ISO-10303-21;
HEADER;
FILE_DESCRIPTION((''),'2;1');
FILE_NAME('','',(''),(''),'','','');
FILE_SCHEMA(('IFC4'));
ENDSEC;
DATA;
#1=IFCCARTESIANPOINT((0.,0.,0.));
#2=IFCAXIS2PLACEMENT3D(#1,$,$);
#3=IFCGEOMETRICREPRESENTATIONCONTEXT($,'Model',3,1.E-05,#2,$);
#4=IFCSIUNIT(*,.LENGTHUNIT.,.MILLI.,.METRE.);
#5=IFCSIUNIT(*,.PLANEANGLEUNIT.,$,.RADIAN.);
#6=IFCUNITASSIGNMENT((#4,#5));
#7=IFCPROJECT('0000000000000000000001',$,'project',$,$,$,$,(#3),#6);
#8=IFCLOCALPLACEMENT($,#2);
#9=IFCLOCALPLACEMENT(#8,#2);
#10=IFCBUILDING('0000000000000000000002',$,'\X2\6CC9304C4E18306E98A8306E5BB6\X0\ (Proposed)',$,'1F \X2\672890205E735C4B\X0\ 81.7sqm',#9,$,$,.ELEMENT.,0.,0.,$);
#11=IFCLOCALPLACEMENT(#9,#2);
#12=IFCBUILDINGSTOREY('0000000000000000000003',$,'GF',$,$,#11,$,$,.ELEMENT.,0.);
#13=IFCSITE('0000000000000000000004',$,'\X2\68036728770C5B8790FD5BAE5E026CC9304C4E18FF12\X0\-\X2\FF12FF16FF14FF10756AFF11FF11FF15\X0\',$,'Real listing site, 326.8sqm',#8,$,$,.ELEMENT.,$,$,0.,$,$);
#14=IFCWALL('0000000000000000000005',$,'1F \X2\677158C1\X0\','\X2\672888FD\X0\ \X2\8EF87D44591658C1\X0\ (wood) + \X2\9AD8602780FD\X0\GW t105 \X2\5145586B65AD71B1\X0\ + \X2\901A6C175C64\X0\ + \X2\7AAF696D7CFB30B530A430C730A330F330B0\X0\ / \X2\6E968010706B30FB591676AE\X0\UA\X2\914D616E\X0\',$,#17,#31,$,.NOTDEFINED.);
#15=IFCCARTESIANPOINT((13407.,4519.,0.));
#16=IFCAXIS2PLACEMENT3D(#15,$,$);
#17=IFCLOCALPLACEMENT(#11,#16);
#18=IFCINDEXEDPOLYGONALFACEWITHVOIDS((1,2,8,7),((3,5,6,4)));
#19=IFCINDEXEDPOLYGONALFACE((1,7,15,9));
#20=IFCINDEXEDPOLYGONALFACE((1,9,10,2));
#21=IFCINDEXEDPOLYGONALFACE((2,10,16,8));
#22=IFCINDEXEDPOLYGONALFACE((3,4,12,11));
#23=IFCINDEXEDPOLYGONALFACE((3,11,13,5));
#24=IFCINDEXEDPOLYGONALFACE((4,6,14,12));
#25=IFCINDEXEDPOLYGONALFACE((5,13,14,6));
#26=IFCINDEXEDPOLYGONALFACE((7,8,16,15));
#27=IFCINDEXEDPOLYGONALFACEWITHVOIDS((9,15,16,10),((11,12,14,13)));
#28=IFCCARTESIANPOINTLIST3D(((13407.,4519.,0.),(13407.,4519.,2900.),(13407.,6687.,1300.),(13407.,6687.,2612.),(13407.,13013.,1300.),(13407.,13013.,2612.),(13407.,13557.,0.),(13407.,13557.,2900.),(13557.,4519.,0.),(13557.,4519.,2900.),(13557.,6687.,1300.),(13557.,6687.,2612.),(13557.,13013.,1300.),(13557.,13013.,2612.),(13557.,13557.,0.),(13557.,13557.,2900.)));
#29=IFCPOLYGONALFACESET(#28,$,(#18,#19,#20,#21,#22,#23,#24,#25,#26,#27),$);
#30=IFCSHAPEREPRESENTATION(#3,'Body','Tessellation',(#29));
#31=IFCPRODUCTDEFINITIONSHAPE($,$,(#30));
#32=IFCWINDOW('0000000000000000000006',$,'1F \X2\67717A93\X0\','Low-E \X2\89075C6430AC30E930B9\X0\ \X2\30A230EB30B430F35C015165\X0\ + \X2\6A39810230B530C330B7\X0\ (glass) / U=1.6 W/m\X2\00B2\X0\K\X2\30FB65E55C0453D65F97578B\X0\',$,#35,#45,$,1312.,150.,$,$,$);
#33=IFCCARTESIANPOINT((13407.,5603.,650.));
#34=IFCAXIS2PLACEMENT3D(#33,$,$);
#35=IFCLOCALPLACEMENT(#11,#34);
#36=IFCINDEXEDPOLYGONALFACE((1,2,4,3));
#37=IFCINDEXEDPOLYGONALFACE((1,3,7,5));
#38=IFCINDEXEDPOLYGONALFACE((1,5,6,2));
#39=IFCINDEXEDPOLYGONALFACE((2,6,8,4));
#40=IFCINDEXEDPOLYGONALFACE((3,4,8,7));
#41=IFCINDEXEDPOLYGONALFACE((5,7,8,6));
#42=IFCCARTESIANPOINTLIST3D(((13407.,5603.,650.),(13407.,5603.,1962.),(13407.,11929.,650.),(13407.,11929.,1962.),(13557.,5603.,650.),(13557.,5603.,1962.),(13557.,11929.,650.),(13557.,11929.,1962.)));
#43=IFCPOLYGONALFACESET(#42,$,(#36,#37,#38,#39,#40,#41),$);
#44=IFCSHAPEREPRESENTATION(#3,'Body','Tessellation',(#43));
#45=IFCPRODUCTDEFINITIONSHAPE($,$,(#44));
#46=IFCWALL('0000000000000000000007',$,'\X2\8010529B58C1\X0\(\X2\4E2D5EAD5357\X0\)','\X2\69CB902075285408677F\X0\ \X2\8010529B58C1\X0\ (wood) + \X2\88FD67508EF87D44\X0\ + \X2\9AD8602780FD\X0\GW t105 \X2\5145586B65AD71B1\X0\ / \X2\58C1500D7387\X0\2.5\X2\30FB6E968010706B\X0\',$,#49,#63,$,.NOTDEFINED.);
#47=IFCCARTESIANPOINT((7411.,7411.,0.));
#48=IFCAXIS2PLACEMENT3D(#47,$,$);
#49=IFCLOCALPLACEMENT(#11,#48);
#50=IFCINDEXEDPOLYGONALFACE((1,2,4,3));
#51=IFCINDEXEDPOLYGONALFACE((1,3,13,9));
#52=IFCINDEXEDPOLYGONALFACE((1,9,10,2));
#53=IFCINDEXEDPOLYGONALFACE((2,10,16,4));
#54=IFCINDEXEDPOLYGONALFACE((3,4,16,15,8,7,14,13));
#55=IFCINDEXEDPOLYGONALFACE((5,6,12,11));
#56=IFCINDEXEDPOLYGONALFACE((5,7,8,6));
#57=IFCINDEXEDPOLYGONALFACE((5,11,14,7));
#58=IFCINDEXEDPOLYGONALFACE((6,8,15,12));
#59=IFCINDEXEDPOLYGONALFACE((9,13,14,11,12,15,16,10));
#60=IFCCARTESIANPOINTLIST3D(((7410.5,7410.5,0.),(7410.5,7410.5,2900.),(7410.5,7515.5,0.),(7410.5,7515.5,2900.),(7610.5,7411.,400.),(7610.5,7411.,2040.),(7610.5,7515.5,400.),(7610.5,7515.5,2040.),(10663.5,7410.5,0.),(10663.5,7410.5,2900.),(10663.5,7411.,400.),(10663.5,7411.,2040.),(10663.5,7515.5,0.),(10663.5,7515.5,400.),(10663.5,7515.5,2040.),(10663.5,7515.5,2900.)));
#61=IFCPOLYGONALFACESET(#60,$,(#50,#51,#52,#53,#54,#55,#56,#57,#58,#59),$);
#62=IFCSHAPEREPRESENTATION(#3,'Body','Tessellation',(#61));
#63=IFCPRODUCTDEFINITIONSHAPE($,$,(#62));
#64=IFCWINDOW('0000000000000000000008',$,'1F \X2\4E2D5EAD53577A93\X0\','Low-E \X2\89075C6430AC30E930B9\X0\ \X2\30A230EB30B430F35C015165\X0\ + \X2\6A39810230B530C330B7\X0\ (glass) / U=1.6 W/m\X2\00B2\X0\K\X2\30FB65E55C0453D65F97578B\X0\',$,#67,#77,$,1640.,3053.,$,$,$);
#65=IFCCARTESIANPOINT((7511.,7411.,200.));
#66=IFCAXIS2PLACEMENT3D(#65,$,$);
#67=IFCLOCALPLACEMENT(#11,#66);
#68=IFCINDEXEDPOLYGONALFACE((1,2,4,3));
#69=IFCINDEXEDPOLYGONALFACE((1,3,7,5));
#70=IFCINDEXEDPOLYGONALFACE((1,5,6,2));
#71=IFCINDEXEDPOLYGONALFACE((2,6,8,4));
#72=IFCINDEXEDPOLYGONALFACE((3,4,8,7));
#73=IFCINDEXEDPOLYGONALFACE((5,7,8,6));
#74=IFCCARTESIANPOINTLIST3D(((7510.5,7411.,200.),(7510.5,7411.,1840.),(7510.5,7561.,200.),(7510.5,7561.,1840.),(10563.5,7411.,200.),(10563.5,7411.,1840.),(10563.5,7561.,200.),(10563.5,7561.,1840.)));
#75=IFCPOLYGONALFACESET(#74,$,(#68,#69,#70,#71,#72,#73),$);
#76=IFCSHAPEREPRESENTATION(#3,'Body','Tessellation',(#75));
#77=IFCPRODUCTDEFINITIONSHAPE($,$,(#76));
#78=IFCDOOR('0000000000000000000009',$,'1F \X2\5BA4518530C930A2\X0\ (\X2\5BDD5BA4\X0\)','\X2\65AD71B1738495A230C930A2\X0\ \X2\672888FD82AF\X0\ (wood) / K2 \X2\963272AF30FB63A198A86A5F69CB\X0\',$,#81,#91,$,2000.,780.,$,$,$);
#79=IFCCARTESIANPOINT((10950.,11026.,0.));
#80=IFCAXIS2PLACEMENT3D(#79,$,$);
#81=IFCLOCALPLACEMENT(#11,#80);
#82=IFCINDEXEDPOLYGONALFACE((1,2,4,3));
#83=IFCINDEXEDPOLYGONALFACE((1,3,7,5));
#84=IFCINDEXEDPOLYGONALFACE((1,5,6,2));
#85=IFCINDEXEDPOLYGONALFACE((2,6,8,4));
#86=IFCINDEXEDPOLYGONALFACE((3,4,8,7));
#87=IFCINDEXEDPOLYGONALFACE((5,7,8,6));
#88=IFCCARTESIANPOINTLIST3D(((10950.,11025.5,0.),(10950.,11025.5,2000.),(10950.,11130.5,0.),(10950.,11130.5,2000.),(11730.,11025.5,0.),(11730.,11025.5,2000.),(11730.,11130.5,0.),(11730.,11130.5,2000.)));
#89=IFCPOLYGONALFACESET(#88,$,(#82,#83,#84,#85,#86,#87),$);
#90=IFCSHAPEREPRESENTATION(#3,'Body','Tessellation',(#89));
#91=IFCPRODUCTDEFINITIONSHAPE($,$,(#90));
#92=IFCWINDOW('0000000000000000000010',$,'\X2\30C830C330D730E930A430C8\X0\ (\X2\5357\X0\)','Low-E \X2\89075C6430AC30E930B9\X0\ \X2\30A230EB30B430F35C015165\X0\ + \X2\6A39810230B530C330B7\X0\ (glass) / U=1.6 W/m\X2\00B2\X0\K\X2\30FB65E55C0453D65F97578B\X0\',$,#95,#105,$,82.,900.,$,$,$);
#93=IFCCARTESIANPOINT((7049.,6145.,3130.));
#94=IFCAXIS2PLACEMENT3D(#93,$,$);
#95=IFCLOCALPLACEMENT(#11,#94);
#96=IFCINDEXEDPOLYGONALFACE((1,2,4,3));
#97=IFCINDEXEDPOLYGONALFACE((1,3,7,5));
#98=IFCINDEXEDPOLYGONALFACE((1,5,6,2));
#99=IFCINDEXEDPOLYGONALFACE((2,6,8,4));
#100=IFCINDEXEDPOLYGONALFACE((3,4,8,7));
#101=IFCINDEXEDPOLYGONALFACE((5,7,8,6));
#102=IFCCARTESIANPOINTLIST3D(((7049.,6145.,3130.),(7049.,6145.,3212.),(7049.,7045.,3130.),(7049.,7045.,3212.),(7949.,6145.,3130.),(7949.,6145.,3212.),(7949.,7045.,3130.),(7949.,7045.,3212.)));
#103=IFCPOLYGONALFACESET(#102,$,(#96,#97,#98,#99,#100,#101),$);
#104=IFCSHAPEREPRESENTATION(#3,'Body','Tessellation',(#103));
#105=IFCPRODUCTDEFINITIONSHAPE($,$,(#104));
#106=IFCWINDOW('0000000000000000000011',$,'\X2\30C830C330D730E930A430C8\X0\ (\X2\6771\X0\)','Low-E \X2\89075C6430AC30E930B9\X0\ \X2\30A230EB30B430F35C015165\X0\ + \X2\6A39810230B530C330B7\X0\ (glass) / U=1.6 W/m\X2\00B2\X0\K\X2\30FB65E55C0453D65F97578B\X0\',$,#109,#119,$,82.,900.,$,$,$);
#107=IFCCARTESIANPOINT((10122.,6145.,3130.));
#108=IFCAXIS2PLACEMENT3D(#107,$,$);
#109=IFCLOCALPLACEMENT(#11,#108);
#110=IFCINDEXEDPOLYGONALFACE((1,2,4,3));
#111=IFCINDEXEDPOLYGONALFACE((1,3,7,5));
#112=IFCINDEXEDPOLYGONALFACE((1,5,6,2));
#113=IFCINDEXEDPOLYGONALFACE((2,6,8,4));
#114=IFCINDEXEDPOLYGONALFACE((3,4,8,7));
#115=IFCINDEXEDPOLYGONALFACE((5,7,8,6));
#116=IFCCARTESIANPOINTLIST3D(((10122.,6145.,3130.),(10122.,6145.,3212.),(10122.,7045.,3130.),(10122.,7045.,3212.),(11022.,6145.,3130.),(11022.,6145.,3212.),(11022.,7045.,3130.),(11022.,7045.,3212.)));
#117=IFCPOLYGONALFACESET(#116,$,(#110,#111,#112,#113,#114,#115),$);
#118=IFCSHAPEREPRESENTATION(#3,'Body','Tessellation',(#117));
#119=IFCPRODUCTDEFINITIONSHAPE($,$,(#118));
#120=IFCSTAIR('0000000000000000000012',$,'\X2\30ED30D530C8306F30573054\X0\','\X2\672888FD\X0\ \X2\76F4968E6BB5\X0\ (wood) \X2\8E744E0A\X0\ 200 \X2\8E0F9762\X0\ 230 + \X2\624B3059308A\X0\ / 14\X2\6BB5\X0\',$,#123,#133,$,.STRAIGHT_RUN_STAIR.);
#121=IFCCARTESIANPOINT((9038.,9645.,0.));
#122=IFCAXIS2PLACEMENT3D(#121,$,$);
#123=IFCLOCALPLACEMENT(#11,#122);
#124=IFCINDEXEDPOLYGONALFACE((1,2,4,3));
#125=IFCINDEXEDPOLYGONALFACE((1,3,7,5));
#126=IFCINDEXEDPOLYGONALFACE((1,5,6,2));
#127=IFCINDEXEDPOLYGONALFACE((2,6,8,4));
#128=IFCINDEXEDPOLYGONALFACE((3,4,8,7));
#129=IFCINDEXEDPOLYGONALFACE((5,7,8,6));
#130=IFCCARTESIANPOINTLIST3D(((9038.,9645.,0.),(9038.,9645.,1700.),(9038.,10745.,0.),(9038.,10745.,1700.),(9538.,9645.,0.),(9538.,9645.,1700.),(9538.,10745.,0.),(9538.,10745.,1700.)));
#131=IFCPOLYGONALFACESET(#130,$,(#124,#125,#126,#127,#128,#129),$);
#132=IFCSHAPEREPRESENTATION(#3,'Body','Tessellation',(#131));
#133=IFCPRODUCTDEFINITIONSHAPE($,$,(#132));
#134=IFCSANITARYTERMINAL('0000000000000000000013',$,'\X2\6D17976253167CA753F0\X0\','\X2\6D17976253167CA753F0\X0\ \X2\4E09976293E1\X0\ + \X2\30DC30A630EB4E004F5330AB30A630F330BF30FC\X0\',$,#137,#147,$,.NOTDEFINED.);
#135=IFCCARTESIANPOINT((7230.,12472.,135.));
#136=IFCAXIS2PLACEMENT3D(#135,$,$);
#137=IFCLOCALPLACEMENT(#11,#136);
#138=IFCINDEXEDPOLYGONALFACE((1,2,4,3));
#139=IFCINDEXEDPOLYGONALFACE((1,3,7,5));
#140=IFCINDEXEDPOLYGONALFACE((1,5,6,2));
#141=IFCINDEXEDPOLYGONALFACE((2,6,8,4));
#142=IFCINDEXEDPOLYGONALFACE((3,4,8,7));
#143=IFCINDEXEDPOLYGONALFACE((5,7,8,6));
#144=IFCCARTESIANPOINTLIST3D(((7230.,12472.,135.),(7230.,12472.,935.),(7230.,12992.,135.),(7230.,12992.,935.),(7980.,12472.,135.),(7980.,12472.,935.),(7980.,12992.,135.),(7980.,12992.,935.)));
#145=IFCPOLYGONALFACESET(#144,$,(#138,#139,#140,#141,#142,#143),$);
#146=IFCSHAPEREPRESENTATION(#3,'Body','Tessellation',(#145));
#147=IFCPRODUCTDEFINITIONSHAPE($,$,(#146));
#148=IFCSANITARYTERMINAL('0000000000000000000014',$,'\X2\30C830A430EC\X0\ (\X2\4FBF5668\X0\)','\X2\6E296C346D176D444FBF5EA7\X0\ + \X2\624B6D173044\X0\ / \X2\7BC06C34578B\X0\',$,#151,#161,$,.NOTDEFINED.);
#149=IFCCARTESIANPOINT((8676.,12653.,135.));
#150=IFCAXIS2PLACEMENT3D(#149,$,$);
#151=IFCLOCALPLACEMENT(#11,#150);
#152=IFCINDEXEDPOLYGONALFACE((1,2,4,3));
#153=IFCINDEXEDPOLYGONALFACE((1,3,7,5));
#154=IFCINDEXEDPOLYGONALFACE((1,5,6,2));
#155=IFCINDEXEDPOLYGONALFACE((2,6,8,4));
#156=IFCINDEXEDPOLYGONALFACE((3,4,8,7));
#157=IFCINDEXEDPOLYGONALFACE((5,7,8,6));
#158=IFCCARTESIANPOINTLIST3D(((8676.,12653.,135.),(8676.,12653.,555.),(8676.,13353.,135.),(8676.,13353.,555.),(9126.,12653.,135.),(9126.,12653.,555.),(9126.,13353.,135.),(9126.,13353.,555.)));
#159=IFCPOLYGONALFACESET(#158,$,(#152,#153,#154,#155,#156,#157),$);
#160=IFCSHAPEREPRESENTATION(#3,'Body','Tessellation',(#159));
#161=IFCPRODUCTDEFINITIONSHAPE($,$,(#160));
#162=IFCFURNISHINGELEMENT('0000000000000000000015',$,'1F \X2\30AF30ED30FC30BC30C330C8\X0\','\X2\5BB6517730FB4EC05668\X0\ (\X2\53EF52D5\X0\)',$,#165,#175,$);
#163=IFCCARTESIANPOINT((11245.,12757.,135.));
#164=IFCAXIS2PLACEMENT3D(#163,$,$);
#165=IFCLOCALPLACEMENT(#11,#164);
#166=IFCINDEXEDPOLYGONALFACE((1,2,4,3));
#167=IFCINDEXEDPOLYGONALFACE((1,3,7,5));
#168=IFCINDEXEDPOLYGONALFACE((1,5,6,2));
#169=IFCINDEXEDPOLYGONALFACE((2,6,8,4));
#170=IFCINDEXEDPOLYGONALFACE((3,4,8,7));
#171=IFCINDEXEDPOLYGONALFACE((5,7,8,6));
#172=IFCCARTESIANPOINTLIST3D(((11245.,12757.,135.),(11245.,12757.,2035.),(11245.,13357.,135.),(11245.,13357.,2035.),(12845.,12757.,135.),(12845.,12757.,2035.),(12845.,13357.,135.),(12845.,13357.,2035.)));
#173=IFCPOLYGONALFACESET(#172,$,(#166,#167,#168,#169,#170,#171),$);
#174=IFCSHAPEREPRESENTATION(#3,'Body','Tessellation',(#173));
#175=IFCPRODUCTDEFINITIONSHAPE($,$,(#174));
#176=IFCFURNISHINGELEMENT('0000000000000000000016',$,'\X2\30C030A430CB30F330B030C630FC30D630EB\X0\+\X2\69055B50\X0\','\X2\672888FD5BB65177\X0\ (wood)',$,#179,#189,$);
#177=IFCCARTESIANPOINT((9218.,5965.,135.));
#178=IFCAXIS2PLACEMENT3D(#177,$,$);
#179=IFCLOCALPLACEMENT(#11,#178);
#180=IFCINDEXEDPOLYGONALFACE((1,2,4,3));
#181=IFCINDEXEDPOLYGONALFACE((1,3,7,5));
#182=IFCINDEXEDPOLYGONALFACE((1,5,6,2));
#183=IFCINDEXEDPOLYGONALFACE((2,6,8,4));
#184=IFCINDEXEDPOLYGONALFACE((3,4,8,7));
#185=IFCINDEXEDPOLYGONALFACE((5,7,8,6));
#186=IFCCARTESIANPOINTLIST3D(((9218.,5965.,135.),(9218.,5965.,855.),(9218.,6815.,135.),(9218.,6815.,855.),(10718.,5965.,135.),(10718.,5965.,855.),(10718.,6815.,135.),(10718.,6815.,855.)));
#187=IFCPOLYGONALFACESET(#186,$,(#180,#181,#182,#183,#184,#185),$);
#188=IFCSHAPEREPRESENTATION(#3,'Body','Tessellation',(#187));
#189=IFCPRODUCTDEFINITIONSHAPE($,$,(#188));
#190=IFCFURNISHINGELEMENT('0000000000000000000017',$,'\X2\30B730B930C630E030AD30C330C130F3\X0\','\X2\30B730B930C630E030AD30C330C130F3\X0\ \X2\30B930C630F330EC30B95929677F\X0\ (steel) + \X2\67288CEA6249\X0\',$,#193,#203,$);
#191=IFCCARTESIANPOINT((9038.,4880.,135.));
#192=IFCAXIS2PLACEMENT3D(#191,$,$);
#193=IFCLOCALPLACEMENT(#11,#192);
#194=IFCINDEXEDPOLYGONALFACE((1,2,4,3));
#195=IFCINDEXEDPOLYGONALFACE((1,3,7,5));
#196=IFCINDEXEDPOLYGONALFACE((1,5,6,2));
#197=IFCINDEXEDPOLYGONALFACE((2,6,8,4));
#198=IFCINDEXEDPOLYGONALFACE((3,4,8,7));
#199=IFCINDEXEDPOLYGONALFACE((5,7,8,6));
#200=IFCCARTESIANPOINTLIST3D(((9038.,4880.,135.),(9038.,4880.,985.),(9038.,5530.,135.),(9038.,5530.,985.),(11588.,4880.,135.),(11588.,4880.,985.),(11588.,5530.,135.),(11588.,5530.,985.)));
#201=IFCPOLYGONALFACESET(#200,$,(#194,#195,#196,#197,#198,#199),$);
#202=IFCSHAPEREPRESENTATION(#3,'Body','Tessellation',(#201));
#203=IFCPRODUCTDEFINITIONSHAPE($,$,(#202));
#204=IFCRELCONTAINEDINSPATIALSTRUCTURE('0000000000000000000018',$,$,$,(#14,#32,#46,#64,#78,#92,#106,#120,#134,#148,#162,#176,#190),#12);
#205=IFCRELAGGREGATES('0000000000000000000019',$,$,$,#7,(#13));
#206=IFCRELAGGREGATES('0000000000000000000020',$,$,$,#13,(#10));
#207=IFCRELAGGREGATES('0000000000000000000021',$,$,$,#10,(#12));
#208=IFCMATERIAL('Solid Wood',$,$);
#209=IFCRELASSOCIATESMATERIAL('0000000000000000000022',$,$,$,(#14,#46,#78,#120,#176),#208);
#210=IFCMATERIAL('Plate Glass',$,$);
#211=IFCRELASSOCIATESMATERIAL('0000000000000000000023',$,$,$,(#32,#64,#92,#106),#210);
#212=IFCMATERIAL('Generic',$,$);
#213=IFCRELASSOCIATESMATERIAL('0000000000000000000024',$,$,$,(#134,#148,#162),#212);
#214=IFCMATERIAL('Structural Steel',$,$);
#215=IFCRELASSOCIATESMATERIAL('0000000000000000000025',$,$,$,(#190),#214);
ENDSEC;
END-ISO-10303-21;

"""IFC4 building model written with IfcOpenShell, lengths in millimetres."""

from ifc_helpers import new_model, si_unit, frame, frame_2d, origin, place, context, project, spatial, rectangle, extrude, material, element, fill, save


model = new_model("IFC4")

# Units and contexts
model_context = context("Model", 3, precision=1e-05, world=origin())
ifc_project = project(units=[si_unit("LENGTHUNIT", "METRE", prefix="MILLI"), si_unit("PLANEANGLEUNIT", "RADIAN")], contexts=[model_context])

# Site, building, storey
site_placement = place(None, origin())
site = spatial("IfcSite", under=ifc_project, at=site_placement, Name="栃木県宇都宮市泉が丘２-２６４０番１１５", ObjectType="Real listing site, 326.8sqm", CompositionType="ELEMENT", RefElevation=0.0)
building_placement = place(site_placement, origin())
building = spatial("IfcBuilding", under=site, at=building_placement, Name="泉が丘の風の家 (Proposed)", ObjectType="1F 木造平屋 81.7sqm", CompositionType="ELEMENT", ElevationOfRefHeight=0.0, ElevationOfTerrain=0.0)
storey_placement = place(building_placement, origin())
storey = spatial("IfcBuildingStorey", under=building, at=storey_placement, Name="GF", CompositionType="ELEMENT", Elevation=0.0)

# Shared definitions
ifc_material_1 = material(Name="Solid Wood")

# Walls, openings, windows
wall_1_placement = place(storey_placement, frame((13407.0, 4519.0, 0.0)))
wall_1 = element("IfcWall", 1, at=wall_1_placement, inside=storey, material=ifc_material_1, Name="1F 東壁", Description="木製 軸組外壁 (wood) + 高性能GW t105 充填断熱 + 通気層 + 窯業系サイディング / 準耐火・外皮UA配慮", PredefinedType="NOTDEFINED", context=model_context, shape_type="SweptSolid", body=[
    extrude(rectangle(XDim=150.0, YDim=9038.0, at=frame_2d((75.0, 4519.0))), frame((13407.0, 4519.0, 0.0)), (0.0, 0.0, 1.0), 2900.0),
])
opening_1_placement = place(storey_placement, frame((13407.0, 5603.0, 650.0)))
opening_1 = element("IfcOpeningElement", 2, at=opening_1_placement, cuts=wall_1, PredefinedType="NOTDEFINED", context=model_context, shape_type="SweptSolid", body=[
    extrude(rectangle(XDim=150.0, YDim=6326.0, at=frame_2d((75.0, 3163.0))), frame((13407.0, 5603.0, 650.0)), (0.0, 0.0, 1.0), 1312.0),
])
ifc_material_2 = material(Name="Plate Glass")
window_1_placement = place(storey_placement, frame((13407.0, 5603.0, 650.0)))
window_1 = element("IfcWindow", 3, at=window_1_placement, inside=storey, material=ifc_material_2, Name="1F 東窓", Description="Low-E 複層ガラス アルゴン封入 + 樹脂サッシ (glass) / U=1.6 W/m²K・日射取得型", OverallHeight=1312.0, OverallWidth=150.0, context=model_context, shape_type="SweptSolid", body=[
    extrude(rectangle(XDim=150.0, YDim=6326.0, at=frame_2d((75.0, 3163.0))), frame((13407.0, 5603.0, 650.0)), (0.0, 0.0, 1.0), 1312.0),
])
fill(opening_1, window_1)
wall_2_placement = place(storey_placement, frame((7411.0, 7411.0, 0.0)))
wall_2 = element("IfcWall", 4, at=wall_2_placement, inside=storey, material=ifc_material_1, Name="耐力壁(中庭南)", Description="構造用合板 耐力壁 (wood) + 製材軸組 + 高性能GW t105 充填断熱 / 壁倍率2.5・準耐火", PredefinedType="NOTDEFINED", context=model_context, shape_type="SweptSolid", body=[
    extrude(rectangle(XDim=3253.0, YDim=105.0, at=frame_2d((1626.0, 52.0))), frame((7411.0, 7411.0, 0.0)), (0.0, 0.0, 1.0), 2900.0),
])
opening_2_placement = place(storey_placement, frame((7511.0, 7411.0, 200.0)))
opening_2 = element("IfcOpeningElement", 5, at=opening_2_placement, cuts=wall_2, PredefinedType="NOTDEFINED", context=model_context, shape_type="SweptSolid", body=[
    extrude(rectangle(XDim=3053.0, YDim=150.0, at=frame_2d((1526.0, 75.0))), frame((7511.0, 7411.0, 200.0)), (0.0, 0.0, 1.0), 1640.0),
])
window_2_placement = place(storey_placement, frame((7511.0, 7411.0, 200.0)))
window_2 = element("IfcWindow", 6, at=window_2_placement, inside=storey, material=ifc_material_2, Name="1F 中庭南窓", Description="Low-E 複層ガラス アルゴン封入 + 樹脂サッシ (glass) / U=1.6 W/m²K・日射取得型", OverallHeight=1640.0, OverallWidth=3053.0, context=model_context, shape_type="SweptSolid", body=[
    extrude(rectangle(XDim=3053.0, YDim=150.0, at=frame_2d((1526.0, 75.0))), frame((7511.0, 7411.0, 200.0)), (0.0, 0.0, 1.0), 1640.0),
])
fill(opening_2, window_2)

# Door
door_placement = place(storey_placement, frame((10950.0, 11026.0, 0.0)))
element("IfcDoor", 7, at=door_placement, inside=storey, material=ifc_material_1, Name="1F 室内ドア (寝室)", Description="断熱玄関ドア 木製芯 (wood) / K2 防犯・採風機構", OverallHeight=2000.0, OverallWidth=780.0, context=model_context, shape_type="SweptSolid", body=[
    extrude(rectangle(XDim=780.0, YDim=105.0, at=frame_2d((390.0, 52.0))), frame((10950.0, 11026.0, 0.0)), (0.0, 0.0, 1.0), 2000.0),
])

# Windows
window_3_placement = place(storey_placement, frame((7049.0, 6145.0, 3130.0)))
element("IfcWindow", 8, at=window_3_placement, inside=storey, material=ifc_material_2, Name="トップライト (南)", Description="Low-E 複層ガラス アルゴン封入 + 樹脂サッシ (glass) / U=1.6 W/m²K・日射取得型", OverallHeight=82.0, OverallWidth=900.0, context=model_context, shape_type="SweptSolid", body=[
    extrude(rectangle(XDim=900.0, YDim=900.0, at=frame_2d((450.0, 450.0))), frame((7049.0, 6145.0, 3130.0)), (0.0, 0.0, 1.0), 82.0),
])
window_4_placement = place(storey_placement, frame((10122.0, 6145.0, 3130.0)))
element("IfcWindow", 9, at=window_4_placement, inside=storey, material=ifc_material_2, Name="トップライト (東)", Description="Low-E 複層ガラス アルゴン封入 + 樹脂サッシ (glass) / U=1.6 W/m²K・日射取得型", OverallHeight=82.0, OverallWidth=900.0, context=model_context, shape_type="SweptSolid", body=[
    extrude(rectangle(XDim=900.0, YDim=900.0, at=frame_2d((450.0, 450.0))), frame((10122.0, 6145.0, 3130.0)), (0.0, 0.0, 1.0), 82.0),
])

# Stair
stair_placement = place(storey_placement, frame((9038.0, 9645.0, 0.0)))
element("IfcStair", 10, at=stair_placement, inside=storey, material=ifc_material_1, Name="ロフトはしご", Description="木製 直階段 (wood) 蹴上 200 踏面 230 + 手すり / 14段", PredefinedType="STRAIGHT_RUN_STAIR", context=model_context, shape_type="SweptSolid", body=[
    extrude(rectangle(XDim=500.0, YDim=1100.0, at=frame_2d((250.0, 550.0))), frame((9038.0, 9645.0, 0.0)), (0.0, 0.0, 1.0), 1700.0),
])

# Shared definitions
ifc_material_3 = material(Name="Structural Steel")

# Shared definitions
ifc_material_4 = material(Name="Generic")

# Sanitary terminals
sanitary_terminal_1_placement = place(storey_placement, frame((7230.0, 12472.0, 135.0)))
element("IfcSanitaryTerminal", 11, at=sanitary_terminal_1_placement, inside=storey, material=ifc_material_4, Name="洗面化粧台", Description="洗面化粧台 三面鏡 + ボウル一体カウンター", PredefinedType="NOTDEFINED", context=model_context, shape_type="SweptSolid", body=[
    extrude(rectangle(XDim=750.0, YDim=520.0, at=frame_2d((375.0, 260.0))), frame((7230.0, 12472.0, 135.0)), (0.0, 0.0, 1.0), 800.0),
])
sanitary_terminal_2_placement = place(storey_placement, frame((8676.0, 12653.0, 135.0)))
element("IfcSanitaryTerminal", 12, at=sanitary_terminal_2_placement, inside=storey, material=ifc_material_4, Name="トイレ (便器)", Description="温水洗浄便座 + 手洗い / 節水型", PredefinedType="NOTDEFINED", context=model_context, shape_type="SweptSolid", body=[
    extrude(rectangle(XDim=450.0, YDim=700.0, at=frame_2d((225.0, 350.0))), frame((8676.0, 12653.0, 135.0)), (0.0, 0.0, 1.0), 420.0),
])

# Furnishing elements
furnishing_1_placement = place(storey_placement, frame((11245.0, 12757.0, 135.0)))
element("IfcFurnishingElement", 13, at=furnishing_1_placement, inside=storey, material=ifc_material_4, Name="1F クローゼット", Description="家具・什器 (可動)", context=model_context, shape_type="SweptSolid", body=[
    extrude(rectangle(XDim=1600.0, YDim=600.0, at=frame_2d((800.0, 300.0))), frame((11245.0, 12757.0, 135.0)), (0.0, 0.0, 1.0), 1900.0),
])
furnishing_2_placement = place(storey_placement, frame((9218.0, 5965.0, 135.0)))
element("IfcFurnishingElement", 14, at=furnishing_2_placement, inside=storey, material=ifc_material_1, Name="ダイニングテーブル+椅子", Description="木製家具 (wood)", context=model_context, shape_type="SweptSolid", body=[
    extrude(rectangle(XDim=1500.0, YDim=850.0, at=frame_2d((750.0, 425.0))), frame((9218.0, 5965.0, 135.0)), (0.0, 0.0, 1.0), 720.0),
])
furnishing_3_placement = place(storey_placement, frame((9038.0, 4880.0, 135.0)))
element("IfcFurnishingElement", 15, at=furnishing_3_placement, inside=storey, material=ifc_material_3, Name="システムキッチン", Description="システムキッチン ステンレス天板 (steel) + 木質扉", context=model_context, shape_type="SweptSolid", body=[
    extrude(rectangle(XDim=2550.0, YDim=650.0, at=frame_2d((1275.0, 325.0))), frame((9038.0, 4880.0, 135.0)), (0.0, 0.0, 1.0), 850.0),
])

save(model, "model.ifc")
